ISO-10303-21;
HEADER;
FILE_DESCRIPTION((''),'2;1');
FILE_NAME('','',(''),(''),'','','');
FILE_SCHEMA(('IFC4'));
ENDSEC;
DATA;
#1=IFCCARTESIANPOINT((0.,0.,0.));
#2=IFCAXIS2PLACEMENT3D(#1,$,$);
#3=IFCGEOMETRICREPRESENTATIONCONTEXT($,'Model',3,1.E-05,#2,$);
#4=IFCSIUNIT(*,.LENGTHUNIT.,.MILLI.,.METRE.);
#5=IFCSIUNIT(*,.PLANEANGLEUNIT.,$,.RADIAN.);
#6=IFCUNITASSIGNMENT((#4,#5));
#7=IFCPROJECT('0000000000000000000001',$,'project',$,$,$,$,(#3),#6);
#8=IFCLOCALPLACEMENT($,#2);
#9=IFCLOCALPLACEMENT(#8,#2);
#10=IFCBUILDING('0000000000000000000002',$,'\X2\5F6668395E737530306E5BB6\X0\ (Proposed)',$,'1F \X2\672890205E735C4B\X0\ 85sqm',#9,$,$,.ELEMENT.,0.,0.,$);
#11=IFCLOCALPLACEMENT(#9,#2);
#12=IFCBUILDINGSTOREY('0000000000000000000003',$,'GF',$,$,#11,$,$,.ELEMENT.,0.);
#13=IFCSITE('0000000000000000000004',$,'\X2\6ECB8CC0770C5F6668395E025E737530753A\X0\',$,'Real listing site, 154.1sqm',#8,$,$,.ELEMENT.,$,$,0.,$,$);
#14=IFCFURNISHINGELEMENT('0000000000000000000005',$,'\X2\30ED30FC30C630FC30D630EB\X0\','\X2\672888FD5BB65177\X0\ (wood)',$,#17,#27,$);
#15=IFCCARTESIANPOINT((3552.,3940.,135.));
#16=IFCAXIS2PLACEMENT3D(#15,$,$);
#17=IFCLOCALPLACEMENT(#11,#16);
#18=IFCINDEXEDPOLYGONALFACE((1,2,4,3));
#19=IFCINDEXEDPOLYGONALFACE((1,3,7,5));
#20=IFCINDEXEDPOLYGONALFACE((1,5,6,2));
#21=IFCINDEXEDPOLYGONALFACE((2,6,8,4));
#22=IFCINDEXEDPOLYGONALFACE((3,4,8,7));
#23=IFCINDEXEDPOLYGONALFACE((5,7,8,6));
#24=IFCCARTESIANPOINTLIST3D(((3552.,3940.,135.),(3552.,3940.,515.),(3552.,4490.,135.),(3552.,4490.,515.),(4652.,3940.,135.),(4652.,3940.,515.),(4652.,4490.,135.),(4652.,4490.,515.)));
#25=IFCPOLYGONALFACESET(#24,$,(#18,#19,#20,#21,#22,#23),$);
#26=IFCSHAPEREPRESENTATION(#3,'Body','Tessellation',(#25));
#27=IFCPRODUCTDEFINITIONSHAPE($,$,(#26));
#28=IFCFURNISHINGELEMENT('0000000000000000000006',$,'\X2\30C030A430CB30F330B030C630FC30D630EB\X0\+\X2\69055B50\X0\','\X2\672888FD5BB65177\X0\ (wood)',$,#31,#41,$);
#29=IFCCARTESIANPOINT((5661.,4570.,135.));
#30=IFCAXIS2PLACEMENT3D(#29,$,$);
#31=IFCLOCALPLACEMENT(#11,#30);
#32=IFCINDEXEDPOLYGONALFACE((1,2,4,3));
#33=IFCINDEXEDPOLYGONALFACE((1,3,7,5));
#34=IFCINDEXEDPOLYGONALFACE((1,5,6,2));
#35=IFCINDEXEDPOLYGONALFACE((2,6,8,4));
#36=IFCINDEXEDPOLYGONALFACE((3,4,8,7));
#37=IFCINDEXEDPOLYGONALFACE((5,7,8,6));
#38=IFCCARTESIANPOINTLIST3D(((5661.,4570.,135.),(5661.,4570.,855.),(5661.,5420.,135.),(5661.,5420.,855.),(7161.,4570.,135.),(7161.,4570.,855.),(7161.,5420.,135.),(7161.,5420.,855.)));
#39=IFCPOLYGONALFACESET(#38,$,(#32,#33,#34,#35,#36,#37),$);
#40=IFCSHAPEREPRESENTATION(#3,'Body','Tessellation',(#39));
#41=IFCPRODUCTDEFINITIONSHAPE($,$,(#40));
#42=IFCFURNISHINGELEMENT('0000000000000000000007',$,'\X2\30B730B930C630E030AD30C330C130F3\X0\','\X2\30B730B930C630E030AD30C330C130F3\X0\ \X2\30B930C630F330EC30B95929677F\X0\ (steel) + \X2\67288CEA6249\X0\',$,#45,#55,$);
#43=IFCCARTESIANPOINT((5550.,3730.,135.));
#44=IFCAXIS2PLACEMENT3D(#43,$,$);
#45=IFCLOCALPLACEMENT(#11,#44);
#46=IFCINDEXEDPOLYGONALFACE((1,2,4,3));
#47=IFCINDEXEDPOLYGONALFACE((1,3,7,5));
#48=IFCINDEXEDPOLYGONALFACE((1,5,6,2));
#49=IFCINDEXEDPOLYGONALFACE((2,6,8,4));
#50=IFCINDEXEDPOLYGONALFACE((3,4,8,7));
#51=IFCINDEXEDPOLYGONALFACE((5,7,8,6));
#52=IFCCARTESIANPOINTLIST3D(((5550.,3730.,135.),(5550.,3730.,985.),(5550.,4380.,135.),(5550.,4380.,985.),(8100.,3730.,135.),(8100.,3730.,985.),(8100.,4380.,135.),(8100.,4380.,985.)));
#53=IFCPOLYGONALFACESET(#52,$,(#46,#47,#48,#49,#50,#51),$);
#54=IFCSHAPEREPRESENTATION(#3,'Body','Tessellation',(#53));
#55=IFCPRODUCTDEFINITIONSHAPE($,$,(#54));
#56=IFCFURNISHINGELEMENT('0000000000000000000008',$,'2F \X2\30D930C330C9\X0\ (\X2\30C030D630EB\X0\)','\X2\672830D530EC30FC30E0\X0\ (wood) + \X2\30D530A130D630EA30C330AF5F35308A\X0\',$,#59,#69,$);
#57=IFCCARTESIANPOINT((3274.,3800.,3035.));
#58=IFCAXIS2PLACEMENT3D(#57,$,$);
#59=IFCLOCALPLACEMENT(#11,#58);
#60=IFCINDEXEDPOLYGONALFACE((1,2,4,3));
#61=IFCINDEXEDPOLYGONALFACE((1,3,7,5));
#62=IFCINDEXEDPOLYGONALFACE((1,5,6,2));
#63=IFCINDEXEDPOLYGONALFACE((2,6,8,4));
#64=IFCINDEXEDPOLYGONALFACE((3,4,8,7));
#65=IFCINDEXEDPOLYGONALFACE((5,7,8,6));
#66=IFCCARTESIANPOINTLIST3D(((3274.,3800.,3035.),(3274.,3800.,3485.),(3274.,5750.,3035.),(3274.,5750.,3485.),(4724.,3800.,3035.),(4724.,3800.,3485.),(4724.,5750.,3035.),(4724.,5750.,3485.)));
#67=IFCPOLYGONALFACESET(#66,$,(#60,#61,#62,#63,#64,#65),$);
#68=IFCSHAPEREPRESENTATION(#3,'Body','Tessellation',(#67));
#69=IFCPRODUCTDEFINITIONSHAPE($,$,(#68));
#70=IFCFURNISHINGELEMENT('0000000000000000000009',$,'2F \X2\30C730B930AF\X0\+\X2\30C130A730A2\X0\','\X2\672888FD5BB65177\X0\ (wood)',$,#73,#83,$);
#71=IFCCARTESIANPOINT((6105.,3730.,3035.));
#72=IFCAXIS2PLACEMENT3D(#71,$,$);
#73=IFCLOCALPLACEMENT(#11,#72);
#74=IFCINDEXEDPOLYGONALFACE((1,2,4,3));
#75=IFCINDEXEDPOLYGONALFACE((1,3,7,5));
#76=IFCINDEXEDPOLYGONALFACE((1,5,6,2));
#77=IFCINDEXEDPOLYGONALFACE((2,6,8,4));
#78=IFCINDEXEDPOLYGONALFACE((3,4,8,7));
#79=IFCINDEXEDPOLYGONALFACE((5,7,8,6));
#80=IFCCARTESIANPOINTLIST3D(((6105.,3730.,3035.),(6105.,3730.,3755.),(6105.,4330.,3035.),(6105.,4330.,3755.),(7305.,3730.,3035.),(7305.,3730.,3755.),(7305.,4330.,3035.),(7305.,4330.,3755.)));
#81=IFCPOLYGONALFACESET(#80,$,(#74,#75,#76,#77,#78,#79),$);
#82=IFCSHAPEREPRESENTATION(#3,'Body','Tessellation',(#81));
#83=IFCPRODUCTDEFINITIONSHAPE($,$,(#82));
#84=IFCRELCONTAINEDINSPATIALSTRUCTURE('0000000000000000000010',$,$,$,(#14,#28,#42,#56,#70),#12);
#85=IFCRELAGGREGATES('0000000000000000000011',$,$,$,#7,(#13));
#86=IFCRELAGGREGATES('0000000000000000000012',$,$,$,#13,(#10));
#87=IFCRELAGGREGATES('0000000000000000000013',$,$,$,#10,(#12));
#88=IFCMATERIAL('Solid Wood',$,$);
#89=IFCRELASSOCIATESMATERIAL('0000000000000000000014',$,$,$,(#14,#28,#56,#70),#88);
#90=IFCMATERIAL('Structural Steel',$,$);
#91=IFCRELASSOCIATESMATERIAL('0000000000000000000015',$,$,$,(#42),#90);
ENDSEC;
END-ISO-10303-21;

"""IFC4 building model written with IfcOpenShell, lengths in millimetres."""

from ifc_helpers import new_model, si_unit, frame, frame_2d, origin, place, context, project, spatial, rectangle, extrude, material, element, save


model = new_model("IFC4")

# Units and contexts
model_context = context("Model", 3, precision=1e-05, world=origin())
ifc_project = project(units=[si_unit("LENGTHUNIT", "METRE", prefix="MILLI"), si_unit("PLANEANGLEUNIT", "RADIAN")], contexts=[model_context])

# Site, building, storey
site_placement = place(None, origin())
site = spatial("IfcSite", under=ifc_project, at=site_placement, Name="滋賀県彦根市平田町", ObjectType="Real listing site, 154.1sqm", CompositionType="ELEMENT", RefElevation=0.0)
building_placement = place(site_placement, origin())
building = spatial("IfcBuilding", under=site, at=building_placement, Name="彦根平田の家 (Proposed)", ObjectType="1F 木造平屋 85sqm", CompositionType="ELEMENT", ElevationOfRefHeight=0.0, ElevationOfTerrain=0.0)
storey_placement = place(building_placement, origin())
storey = spatial("IfcBuildingStorey", under=building, at=storey_placement, Name="GF", CompositionType="ELEMENT", Elevation=0.0)

# Shared definitions
ifc_material_1 = material(Name="Solid Wood")

# Shared definitions
ifc_material_2 = material(Name="Structural Steel")

# Furnishing elements
furnishing_1_placement = place(storey_placement, frame((3552.0, 3940.0, 135.0)))
element("IfcFurnishingElement", 1, at=furnishing_1_placement, inside=storey, material=ifc_material_1, Name="ローテーブル", Description="木製家具 (wood)", context=model_context, shape_type="SweptSolid", body=[
    extrude(rectangle(XDim=1100.0, YDim=550.0, at=frame_2d((550.0, 275.0))), frame((3552.0, 3940.0, 135.0)), (0.0, 0.0, 1.0), 380.0),
])
furnishing_2_placement = place(storey_placement, frame((5661.0, 4570.0, 135.0)))
element("IfcFurnishingElement", 2, at=furnishing_2_placement, inside=storey, material=ifc_material_1, Name="ダイニングテーブル+椅子", Description="木製家具 (wood)", context=model_context, shape_type="SweptSolid", body=[
    extrude(rectangle(XDim=1500.0, YDim=850.0, at=frame_2d((750.0, 425.0))), frame((5661.0, 4570.0, 135.0)), (0.0, 0.0, 1.0), 720.0),
])
furnishing_3_placement = place(storey_placement, frame((5550.0, 3730.0, 135.0)))
element("IfcFurnishingElement", 3, at=furnishing_3_placement, inside=storey, material=ifc_material_2, Name="システムキッチン", Description="システムキッチン ステンレス天板 (steel) + 木質扉", context=model_context, shape_type="SweptSolid", body=[
    extrude(rectangle(XDim=2550.0, YDim=650.0, at=frame_2d((1275.0, 325.0))), frame((5550.0, 3730.0, 135.0)), (0.0, 0.0, 1.0), 850.0),
])
furnishing_4_placement = place(storey_placement, frame((3274.0, 3800.0, 3035.0)))
element("IfcFurnishingElement", 4, at=furnishing_4_placement, inside=storey, material=ifc_material_1, Name="2F ベッド (ダブル)", Description="木フレーム (wood) + ファブリック張り", context=model_context, shape_type="SweptSolid", body=[
    extrude(rectangle(XDim=1450.0, YDim=1950.0, at=frame_2d((725.0, 975.0))), frame((3274.0, 3800.0, 3035.0)), (0.0, 0.0, 1.0), 450.0),
])
furnishing_5_placement = place(storey_placement, frame((6105.0, 3730.0, 3035.0)))
element("IfcFurnishingElement", 5, at=furnishing_5_placement, inside=storey, material=ifc_material_1, Name="2F デスク+チェア", Description="木製家具 (wood)", context=model_context, shape_type="SweptSolid", body=[
    extrude(rectangle(XDim=1200.0, YDim=600.0, at=frame_2d((600.0, 300.0))), frame((6105.0, 3730.0, 3035.0)), (0.0, 0.0, 1.0), 720.0),
])

save(model, "model.ifc")
